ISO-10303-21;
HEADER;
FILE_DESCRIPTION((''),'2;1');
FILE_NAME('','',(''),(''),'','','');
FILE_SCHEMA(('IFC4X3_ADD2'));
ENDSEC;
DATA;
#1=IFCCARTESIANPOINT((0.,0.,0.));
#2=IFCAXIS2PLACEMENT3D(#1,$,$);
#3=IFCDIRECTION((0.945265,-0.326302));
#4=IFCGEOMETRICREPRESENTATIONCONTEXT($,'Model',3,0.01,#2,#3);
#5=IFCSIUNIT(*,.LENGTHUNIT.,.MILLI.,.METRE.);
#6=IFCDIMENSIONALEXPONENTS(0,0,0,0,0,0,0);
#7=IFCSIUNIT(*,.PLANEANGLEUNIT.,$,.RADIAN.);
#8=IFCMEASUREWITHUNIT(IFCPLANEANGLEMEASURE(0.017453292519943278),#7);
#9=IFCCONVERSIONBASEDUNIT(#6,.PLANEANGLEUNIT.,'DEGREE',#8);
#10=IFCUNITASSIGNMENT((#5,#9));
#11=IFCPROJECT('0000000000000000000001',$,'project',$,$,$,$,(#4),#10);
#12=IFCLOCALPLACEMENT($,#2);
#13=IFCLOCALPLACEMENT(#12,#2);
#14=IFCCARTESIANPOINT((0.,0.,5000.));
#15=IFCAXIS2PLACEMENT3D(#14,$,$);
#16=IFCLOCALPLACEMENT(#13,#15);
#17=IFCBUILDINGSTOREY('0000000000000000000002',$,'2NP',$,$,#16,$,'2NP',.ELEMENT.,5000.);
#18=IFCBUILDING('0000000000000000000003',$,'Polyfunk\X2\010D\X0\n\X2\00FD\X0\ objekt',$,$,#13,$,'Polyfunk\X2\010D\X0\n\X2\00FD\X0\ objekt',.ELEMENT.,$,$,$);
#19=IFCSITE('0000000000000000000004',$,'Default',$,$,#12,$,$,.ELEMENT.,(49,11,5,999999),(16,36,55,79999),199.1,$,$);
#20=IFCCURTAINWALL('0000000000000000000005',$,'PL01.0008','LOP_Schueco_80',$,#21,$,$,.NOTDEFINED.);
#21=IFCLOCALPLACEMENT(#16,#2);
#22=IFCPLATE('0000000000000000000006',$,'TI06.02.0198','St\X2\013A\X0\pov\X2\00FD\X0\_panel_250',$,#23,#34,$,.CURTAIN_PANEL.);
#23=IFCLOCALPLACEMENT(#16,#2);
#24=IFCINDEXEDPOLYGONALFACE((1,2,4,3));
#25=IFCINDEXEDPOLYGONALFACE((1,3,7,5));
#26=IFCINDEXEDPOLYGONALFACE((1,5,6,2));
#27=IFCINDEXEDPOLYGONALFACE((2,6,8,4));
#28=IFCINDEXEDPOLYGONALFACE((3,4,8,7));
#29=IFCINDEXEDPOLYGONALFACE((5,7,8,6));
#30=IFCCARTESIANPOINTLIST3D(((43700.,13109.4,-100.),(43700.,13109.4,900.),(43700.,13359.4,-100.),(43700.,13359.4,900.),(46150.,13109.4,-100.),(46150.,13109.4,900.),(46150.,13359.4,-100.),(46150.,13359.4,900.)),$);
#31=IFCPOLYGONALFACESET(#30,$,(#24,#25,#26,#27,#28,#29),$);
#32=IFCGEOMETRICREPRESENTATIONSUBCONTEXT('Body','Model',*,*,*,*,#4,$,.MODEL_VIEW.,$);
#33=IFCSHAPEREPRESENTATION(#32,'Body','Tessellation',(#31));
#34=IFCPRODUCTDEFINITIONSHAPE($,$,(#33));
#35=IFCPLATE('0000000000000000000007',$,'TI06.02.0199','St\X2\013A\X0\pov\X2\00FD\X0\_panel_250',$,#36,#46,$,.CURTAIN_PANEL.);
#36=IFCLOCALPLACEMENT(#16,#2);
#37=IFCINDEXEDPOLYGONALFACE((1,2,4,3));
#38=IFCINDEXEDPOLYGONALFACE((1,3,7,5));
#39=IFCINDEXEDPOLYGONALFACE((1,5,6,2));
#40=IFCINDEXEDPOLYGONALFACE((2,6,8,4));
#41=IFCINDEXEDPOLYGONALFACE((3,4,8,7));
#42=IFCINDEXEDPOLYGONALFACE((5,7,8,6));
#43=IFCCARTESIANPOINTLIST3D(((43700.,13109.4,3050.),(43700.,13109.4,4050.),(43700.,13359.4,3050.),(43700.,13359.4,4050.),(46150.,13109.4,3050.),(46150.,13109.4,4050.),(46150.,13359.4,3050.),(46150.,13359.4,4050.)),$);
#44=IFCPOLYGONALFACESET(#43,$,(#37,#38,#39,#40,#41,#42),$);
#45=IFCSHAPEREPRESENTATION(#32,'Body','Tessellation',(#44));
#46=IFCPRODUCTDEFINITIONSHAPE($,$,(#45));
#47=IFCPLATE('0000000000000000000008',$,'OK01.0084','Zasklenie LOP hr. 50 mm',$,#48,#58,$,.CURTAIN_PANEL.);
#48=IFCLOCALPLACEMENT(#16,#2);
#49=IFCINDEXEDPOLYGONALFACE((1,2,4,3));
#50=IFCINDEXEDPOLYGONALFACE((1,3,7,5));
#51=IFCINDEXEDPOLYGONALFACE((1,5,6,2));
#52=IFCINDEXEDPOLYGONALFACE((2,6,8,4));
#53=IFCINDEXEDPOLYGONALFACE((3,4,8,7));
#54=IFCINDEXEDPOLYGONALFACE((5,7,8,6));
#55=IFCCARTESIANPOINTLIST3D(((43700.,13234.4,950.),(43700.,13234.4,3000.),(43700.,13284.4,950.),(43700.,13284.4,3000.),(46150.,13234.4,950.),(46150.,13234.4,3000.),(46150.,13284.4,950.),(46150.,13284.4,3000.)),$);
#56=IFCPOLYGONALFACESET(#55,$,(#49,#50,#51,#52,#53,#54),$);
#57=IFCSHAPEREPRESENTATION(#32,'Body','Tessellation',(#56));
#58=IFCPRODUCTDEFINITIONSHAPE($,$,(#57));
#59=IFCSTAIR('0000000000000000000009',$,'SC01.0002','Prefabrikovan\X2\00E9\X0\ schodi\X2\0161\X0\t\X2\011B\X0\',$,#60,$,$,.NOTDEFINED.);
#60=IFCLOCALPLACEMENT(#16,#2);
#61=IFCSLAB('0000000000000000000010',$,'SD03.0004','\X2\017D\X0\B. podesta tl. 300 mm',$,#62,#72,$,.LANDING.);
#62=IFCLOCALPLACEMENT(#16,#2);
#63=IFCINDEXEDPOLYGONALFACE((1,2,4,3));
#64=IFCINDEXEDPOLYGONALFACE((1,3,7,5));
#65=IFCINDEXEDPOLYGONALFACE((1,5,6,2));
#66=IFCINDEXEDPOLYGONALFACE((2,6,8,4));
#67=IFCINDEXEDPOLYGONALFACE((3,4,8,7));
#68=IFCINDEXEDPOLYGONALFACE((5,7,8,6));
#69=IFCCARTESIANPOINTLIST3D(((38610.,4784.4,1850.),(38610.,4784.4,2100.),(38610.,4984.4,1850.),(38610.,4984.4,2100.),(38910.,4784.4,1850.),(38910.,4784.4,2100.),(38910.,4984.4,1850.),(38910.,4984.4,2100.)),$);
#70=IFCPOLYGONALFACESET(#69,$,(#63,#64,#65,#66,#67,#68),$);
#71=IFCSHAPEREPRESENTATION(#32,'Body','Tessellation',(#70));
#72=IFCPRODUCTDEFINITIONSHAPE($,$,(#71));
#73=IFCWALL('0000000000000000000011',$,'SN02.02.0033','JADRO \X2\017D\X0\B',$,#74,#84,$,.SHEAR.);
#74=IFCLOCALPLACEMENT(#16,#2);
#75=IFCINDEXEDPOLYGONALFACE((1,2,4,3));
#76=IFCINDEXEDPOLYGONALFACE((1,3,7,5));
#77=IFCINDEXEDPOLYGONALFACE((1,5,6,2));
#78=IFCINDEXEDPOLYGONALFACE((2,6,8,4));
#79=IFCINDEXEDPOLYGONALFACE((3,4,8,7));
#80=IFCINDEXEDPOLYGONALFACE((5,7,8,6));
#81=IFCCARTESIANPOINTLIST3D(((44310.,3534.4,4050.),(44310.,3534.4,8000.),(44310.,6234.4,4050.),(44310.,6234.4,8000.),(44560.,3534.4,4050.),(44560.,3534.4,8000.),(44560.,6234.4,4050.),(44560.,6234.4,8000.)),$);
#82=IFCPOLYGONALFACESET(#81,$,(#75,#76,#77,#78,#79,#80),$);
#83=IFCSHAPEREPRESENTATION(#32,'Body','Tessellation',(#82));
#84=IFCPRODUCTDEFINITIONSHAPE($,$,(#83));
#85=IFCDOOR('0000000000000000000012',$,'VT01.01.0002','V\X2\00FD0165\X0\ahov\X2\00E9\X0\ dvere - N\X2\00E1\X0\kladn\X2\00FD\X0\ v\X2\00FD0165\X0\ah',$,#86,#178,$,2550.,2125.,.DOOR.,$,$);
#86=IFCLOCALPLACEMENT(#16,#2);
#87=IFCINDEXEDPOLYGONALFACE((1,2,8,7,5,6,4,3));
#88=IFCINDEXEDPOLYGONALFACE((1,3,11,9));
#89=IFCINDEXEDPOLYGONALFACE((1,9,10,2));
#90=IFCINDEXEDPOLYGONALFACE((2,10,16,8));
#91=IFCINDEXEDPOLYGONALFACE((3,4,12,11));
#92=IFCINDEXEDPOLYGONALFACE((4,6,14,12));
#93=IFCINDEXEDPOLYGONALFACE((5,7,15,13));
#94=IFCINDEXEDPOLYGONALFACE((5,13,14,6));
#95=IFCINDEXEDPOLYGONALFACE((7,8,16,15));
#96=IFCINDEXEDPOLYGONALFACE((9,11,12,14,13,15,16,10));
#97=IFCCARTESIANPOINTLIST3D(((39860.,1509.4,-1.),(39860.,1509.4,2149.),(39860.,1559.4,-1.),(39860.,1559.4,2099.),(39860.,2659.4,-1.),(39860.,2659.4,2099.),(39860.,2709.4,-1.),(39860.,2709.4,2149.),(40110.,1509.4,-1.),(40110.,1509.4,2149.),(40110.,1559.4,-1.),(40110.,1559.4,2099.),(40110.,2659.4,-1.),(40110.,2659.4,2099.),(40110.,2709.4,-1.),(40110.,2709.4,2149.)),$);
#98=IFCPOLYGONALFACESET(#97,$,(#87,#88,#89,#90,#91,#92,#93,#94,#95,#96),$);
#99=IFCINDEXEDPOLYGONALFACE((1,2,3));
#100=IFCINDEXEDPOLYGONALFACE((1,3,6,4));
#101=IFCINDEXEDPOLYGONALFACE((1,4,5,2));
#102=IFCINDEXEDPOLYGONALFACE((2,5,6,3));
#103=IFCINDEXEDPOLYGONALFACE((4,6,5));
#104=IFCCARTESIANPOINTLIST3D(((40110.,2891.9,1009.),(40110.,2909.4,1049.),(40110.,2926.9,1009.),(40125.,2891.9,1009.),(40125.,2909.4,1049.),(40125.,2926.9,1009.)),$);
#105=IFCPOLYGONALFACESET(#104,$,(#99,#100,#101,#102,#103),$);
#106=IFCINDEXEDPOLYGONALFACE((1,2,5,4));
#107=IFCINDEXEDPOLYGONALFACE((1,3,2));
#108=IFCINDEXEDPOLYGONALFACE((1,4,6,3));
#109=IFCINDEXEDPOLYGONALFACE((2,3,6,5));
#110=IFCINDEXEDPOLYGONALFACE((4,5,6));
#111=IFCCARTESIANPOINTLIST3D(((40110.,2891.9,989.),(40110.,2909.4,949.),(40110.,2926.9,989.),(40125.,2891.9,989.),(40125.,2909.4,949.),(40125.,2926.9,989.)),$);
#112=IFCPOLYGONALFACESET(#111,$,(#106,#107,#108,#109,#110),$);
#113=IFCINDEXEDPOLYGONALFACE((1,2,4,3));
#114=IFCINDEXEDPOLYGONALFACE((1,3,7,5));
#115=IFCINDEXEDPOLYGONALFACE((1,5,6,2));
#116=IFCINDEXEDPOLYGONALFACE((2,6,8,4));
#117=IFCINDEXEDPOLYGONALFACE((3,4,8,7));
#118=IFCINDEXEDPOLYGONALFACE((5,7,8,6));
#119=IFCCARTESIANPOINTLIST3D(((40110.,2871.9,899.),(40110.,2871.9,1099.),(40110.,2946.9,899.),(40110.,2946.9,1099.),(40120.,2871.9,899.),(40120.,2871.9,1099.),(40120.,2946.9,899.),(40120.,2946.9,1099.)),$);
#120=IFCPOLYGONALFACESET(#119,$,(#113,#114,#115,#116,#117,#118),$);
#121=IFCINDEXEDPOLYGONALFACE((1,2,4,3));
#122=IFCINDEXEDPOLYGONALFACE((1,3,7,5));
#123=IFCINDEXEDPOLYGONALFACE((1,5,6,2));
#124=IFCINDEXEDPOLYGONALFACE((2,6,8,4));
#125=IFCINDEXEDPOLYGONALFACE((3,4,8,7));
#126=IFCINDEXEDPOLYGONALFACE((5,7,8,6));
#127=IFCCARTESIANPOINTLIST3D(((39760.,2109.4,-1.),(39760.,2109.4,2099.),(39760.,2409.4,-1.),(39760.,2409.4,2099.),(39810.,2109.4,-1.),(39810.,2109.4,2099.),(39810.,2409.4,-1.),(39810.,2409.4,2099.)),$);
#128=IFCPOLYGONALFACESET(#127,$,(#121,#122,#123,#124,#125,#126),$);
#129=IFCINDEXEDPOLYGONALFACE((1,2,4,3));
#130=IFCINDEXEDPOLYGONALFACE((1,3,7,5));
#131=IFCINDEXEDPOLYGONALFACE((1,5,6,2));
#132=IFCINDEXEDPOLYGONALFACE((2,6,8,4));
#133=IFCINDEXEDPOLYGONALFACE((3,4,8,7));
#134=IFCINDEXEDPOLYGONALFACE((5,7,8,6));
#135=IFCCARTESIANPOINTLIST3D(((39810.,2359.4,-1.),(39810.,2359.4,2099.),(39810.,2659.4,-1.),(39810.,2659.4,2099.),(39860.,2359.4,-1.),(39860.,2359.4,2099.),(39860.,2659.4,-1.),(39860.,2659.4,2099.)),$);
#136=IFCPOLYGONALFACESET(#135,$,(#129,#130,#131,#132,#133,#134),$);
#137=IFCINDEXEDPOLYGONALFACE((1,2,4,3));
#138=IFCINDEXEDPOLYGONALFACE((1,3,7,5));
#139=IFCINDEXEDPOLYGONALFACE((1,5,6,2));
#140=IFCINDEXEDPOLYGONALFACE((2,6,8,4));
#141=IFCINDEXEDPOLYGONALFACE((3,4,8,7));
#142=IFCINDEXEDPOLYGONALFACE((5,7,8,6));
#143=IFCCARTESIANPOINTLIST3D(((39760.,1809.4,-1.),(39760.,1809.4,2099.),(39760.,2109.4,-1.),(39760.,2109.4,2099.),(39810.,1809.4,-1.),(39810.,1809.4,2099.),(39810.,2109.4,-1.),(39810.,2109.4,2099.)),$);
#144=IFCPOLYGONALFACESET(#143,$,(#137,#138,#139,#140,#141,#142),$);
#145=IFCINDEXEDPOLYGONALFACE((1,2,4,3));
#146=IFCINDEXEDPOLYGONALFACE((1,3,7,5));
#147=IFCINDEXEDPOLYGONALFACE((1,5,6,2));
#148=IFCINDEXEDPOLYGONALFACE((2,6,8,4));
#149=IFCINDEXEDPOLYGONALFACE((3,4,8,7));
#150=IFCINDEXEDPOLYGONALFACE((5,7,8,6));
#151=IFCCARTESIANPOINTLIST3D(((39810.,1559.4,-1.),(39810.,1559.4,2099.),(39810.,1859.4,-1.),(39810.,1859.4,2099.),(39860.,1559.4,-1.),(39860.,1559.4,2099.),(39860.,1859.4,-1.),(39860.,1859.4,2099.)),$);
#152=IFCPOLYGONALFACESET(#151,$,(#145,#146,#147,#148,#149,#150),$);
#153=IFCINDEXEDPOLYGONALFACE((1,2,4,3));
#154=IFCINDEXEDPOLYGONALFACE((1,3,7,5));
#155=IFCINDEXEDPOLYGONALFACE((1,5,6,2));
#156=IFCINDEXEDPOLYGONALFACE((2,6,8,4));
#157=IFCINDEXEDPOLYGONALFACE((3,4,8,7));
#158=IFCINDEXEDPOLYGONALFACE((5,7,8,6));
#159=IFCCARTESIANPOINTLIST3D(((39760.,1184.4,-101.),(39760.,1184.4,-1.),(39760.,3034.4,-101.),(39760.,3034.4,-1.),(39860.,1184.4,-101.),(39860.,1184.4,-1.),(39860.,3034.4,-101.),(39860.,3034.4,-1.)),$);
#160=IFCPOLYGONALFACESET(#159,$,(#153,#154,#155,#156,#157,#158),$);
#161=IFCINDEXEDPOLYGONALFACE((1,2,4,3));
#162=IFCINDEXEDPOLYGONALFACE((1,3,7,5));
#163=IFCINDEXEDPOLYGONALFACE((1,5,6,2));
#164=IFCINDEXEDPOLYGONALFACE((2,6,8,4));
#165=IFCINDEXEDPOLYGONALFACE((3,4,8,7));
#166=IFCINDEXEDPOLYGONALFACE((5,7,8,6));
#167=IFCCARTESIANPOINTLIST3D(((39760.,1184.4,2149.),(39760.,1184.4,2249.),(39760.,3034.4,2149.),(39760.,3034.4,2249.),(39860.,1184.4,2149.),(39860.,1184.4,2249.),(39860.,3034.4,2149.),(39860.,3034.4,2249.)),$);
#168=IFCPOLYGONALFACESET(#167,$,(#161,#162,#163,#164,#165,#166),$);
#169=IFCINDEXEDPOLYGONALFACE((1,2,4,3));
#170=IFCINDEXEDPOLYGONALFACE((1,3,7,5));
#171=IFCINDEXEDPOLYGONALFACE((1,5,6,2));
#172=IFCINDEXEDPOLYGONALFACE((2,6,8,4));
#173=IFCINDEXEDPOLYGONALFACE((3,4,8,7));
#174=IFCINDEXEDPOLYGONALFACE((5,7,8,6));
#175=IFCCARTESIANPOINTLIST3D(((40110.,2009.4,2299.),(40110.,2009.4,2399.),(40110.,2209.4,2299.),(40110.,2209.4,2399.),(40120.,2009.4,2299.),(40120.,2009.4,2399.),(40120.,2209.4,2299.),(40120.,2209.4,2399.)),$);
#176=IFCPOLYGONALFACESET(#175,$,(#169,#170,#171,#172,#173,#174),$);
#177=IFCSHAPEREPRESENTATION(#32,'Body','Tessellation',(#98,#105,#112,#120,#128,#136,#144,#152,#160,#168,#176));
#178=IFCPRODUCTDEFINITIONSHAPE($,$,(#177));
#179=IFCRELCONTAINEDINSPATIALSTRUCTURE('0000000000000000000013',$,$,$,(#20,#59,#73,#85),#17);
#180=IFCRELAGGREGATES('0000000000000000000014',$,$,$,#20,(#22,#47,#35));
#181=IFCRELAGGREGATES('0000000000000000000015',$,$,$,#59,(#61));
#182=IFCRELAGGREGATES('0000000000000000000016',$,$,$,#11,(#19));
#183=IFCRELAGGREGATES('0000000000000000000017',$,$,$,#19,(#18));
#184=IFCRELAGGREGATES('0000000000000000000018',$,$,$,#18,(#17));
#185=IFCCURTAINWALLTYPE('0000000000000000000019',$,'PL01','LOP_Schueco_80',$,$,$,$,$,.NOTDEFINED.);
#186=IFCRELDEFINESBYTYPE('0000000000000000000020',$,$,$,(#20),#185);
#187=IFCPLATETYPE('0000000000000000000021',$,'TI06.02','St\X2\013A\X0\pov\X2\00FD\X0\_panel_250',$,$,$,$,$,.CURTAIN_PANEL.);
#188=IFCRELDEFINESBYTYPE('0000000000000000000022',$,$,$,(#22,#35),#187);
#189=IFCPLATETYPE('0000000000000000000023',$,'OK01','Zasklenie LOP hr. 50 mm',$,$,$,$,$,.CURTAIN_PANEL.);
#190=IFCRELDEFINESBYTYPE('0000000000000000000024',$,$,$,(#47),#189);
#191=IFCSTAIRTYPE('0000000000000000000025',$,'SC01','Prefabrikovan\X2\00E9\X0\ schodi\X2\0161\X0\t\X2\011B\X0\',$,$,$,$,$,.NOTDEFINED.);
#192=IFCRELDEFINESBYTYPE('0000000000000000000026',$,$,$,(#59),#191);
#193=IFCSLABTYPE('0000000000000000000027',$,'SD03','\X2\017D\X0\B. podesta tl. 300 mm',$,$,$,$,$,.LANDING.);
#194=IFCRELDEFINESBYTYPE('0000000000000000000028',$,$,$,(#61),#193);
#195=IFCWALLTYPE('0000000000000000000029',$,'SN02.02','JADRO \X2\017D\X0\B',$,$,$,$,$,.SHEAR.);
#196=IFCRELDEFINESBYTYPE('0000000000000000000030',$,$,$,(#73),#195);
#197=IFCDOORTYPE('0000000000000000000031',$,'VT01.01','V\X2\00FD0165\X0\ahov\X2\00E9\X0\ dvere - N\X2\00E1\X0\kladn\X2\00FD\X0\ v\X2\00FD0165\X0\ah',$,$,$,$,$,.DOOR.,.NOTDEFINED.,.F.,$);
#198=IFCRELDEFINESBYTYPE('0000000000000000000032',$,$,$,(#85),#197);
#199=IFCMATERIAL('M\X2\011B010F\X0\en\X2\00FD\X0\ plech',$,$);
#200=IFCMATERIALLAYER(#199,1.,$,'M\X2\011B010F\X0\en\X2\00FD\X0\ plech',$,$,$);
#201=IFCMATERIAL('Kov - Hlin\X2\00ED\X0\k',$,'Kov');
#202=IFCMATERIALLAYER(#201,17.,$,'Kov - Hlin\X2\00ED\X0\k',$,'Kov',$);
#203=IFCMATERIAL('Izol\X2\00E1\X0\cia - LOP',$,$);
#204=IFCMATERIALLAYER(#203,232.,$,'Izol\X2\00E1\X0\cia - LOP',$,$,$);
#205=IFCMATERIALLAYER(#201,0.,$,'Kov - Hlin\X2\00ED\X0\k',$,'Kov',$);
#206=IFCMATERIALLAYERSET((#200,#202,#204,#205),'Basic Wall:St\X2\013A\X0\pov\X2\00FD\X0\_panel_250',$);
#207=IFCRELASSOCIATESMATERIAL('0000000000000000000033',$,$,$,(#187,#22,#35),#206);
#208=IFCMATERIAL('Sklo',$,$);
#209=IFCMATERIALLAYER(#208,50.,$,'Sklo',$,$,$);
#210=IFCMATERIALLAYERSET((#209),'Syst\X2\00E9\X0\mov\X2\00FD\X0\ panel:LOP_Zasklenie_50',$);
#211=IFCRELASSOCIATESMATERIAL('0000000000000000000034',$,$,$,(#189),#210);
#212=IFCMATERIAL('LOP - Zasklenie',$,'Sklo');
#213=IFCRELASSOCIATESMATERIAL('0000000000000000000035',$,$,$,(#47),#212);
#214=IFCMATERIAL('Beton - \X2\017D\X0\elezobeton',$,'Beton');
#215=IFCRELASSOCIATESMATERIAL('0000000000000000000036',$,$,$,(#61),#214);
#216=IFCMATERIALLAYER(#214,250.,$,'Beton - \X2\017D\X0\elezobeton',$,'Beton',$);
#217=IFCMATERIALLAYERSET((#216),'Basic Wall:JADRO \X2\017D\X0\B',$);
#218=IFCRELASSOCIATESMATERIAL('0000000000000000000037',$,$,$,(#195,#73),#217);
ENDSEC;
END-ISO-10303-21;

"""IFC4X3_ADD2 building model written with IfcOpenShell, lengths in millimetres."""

from ifc_helpers import new_model, entity, si_unit, converted_unit, direction, frame, frame_2d, origin, origin_2d_with_axis, place, context, subcontext, project, spatial, polyline, rectangle, outline, extrude, clip, bounded_halfspace, source, transform, mapped, material, layer, layer_set, layer_usage, type_object, type_shapes, element, aggregate, save


model = new_model("IFC4X3_ADD2")

# Units and contexts
model_context = context("Model", 3, precision=0.01, world=origin(), true_north=direction((0.945265, -0.326302)))
body_context = subcontext(model_context, "Body", "Model", "MODEL_VIEW")
ifc_project = project(units=[si_unit("LENGTHUNIT", "METRE", prefix="MILLI"), converted_unit("PLANEANGLEUNIT", "DEGREE", entity("IfcPlaneAngleMeasure", 0.017453292519943278), si_unit("PLANEANGLEUNIT", "RADIAN"), dimensions=[0, 0, 0, 0, 0, 0, 0])], contexts=[model_context])

# Site, building, storey
site_placement = place(None, origin())
site = spatial("IfcSite", under=ifc_project, at=site_placement, Name="Default", CompositionType="ELEMENT", RefLatitude=(49, 11, 5, 999999), RefLongitude=(16, 36, 55, 79999), RefElevation=199.1)
building_placement = place(site_placement, origin())
building = spatial("IfcBuilding", under=site, at=building_placement, Name="Polyfunkčný objekt", LongName="Polyfunkčný objekt", CompositionType="ELEMENT")
storey_placement = place(building_placement, frame((0.0, 0.0, 5000.0)))
storey = spatial("IfcBuildingStorey", under=building, at=storey_placement, Name="2NP", LongName="2NP", CompositionType="ELEMENT", Elevation=5000.0)

# Curtain wall, plates
curtain_wall_type = type_object("IfcCurtainWallType", Name="PL01", Description="LOP_Schueco_80", PredefinedType="NOTDEFINED")
curtain_wall_placement = place(storey_placement, frame((0.0, 0.0, -5000.0)))
curtain_wall = element("IfcCurtainWall", 1, at=curtain_wall_placement, inside=storey, type_object=curtain_wall_type, Name="PL01.0008", Description="LOP_Schueco_80", PredefinedType="NOTDEFINED")
ifc_material_1 = material(Name="Měďený plech")
ifc_layer_1 = layer(ifc_material_1, 1.0, Name="Měďený plech")
ifc_material_2 = material(Name="Kov - Hliník", Category="Kov")
ifc_layer_2 = layer(ifc_material_2, 17.0, Name="Kov - Hliník", Category="Kov")
ifc_material_3 = material(Name="Izolácia - LOP")
ifc_layer_3 = layer(ifc_material_3, 232.0, Name="Izolácia - LOP")
ifc_layer_4 = layer(ifc_material_2, 0.0, Name="Kov - Hliník", Category="Kov")
ifc_layer_set_1 = layer_set([ifc_layer_1, ifc_layer_2, ifc_layer_3, ifc_layer_4], Name="Basic Wall:Stĺpový_panel_250")
ifc_layer_usage_1 = layer_usage(ifc_layer_set_1, "AXIS2", "NEGATIVE", 125.0)
plate_type_1 = type_object("IfcPlateType", Name="TI06.02", Description="Stĺpový_panel_250", PredefinedType="CURTAIN_PANEL", material=ifc_layer_set_1)
plate_1_placement = place(storey_placement, frame((43700.0, 13234.4, -100.0)))
plate_1 = element("IfcPlate", 2, at=plate_1_placement, type_object=plate_type_1, material=ifc_layer_usage_1, Name="TI06.02.0198", Description="Stĺpový_panel_250", PredefinedType="CURTAIN_PANEL", context=body_context, shape_type="SweptSolid", body=[
    extrude(rectangle(XDim=250.0, YDim=2450.0, at=frame_2d((0.0, 0.0), x_axis=(1.0, 0.0))), frame((1225.0, 0.0, 0.0), z_axis=(0.0, 0.0, 1.0), x_axis=(0.0, 1.0, 0.0)), (0.0, 0.0, 1.0), 1000.0),
])
ifc_layer_usage_2 = layer_usage(ifc_layer_set_1, "AXIS2", "NEGATIVE", 125.0)
plate_2_placement = place(storey_placement, frame((43700.0, 13234.4, 3050.0)))
plate_2 = element("IfcPlate", 3, at=plate_2_placement, type_object=plate_type_1, material=ifc_layer_usage_2, Name="TI06.02.0199", Description="Stĺpový_panel_250", PredefinedType="CURTAIN_PANEL", context=body_context, shape_type="SweptSolid", body=[
    extrude(rectangle(XDim=250.0, YDim=2450.0, at=frame_2d((0.0, 0.0), x_axis=(1.0, 0.0))), frame((1225.0, 0.0, 0.0), z_axis=(0.0, 0.0, 1.0), x_axis=(0.0, 1.0, 0.0)), (0.0, 0.0, 1.0), 1000.0),
])
ifc_material_4 = material(Name="LOP - Zasklenie", Category="Sklo")
ifc_material_5 = material(Name="Sklo")
ifc_layer_5 = layer(ifc_material_5, 50.0, Name="Sklo")
ifc_layer_set_2 = layer_set([ifc_layer_5], Name="Systémový panel:LOP_Zasklenie_50")
plate_type_2 = type_object("IfcPlateType", Name="OK01", Description="Zasklenie LOP hr. 50 mm", PredefinedType="CURTAIN_PANEL", material=ifc_layer_set_2)
shared_shape_1 = source(origin(), body_context, "Body", "SweptSolid", [
    extrude(rectangle(XDim=50.0, YDim=2450.0, at=origin_2d_with_axis()), frame((0.0, 25.0, 0.0), z_axis=(0.0, 0.0, 1.0), x_axis=(0.0, 1.0, 0.0)), (0.0, 0.0, 1.0), 2050.0),
])
type_shapes(plate_type_2, [shared_shape_1])
plate_3_placement = place(curtain_wall_placement, frame((44925.0, 13234.4, 5950.0)))
plate_3 = element("IfcPlate", 4, at=plate_3_placement, type_object=plate_type_2, material=ifc_material_4, Name="OK01.0084", Description="Zasklenie LOP hr. 50 mm", PredefinedType="CURTAIN_PANEL", context=body_context, shape_type="MappedRepresentation", body=[
    mapped(shared_shape_1, transform((0.0, 0.0, 0.0), scale=1.0)),
])
aggregate(curtain_wall, [plate_1, plate_3, plate_2])

# Stair, slab
stair_type = type_object("IfcStairType", Name="SC01", Description="Prefabrikované schodiště", PredefinedType="NOTDEFINED")
stair_placement = place(storey_placement, origin())
stair = element("IfcStair", 5, at=stair_placement, inside=storey, type_object=stair_type, Name="SC01.0002", Description="Prefabrikované schodiště", PredefinedType="NOTDEFINED")
ifc_material_6 = material(Name="Beton - Železobeton", Category="Beton")
slab_type = type_object("IfcSlabType", Name="SD03", Description="ŽB. podesta tl. 300 mm", PredefinedType="LANDING")
slab_placement = place(stair_placement, frame((38610.0, 4784.4, 0.0)))
slab = element("IfcSlab", 6, at=slab_placement, type_object=slab_type, material=ifc_material_6, Name="SD03.0004", Description="ŽB. podesta tl. 300 mm", PredefinedType="LANDING", context=body_context, shape_type="SweptSolid", body=[
    extrude(rectangle(XDim=200.0, YDim=300.0, at=frame_2d((0.0, 0.0), x_axis=(1.0, 0.0))), frame((150.0, 100.0, 1850.0), z_axis=(0.0, 0.0, 1.0), x_axis=(0.0, 1.0, 0.0)), (0.0, 0.0, 1.0), 250.0),
])
aggregate(stair, [slab])

# Wall
ifc_layer_6 = layer(ifc_material_6, 250.0, Name="Beton - Železobeton", Category="Beton")
ifc_layer_set_3 = layer_set([ifc_layer_6], Name="Basic Wall:JADRO ŽB")
wall_type = type_object("IfcWallType", Name="SN02.02", Description="JADRO ŽB", PredefinedType="SHEAR", material=ifc_layer_set_3)
wall_placement = place(storey_placement, frame((44435.0, 6234.4, 4050.0), z_axis=(0.0, 0.0, 1.0), x_axis=(0.0, -1.0, 0.0)))
element("IfcWall", 7, at=wall_placement, inside=storey, type_object=wall_type, material=ifc_layer_set_3, Name="SN02.02.0033", Description="JADRO ŽB", PredefinedType="SHEAR", context=body_context, shape_type="Clipping", body=[
    clip(clip(extrude(rectangle(XDim=2700.0, YDim=250.0, at=frame_2d((1350.0, 0.0), x_axis=(-1.0, 0.0))), origin(), (0.0, 0.0, 1.0), 3950.0), bounded_halfspace(frame((2700.0, -125.0, 0.0), z_axis=(0.0, 0.0, 1.0), x_axis=(0.0, -1.0, 0.0)), True, frame((2700.0, -125.0, 0.0)), polyline([(0.0, 0.0), (0.0, 250.0), (-2700.0, 250.0), (-2700.0, 0.0), (0.0, 0.0)]))), bounded_halfspace(frame((0.0, -125.0, 3950.0), z_axis=(0.0, 0.0, -1.0), x_axis=(0.0, 1.0, 0.0)), True, frame((0.0, -125.0, 3950.0)), polyline([(0.0, 0.0), (2700.0, 0.0), (2700.0, 250.0), (0.0, 250.0), (0.0, 0.0)]))),
])

# Door
door_type = type_object("IfcDoorType", Name="VT01.01", Description="Výťahové dvere - Nákladný výťah", OperationType="NOTDEFINED", ParameterTakesPrecedence=False, PredefinedType="DOOR")
shared_shape_2 = source(origin(), body_context, "Body", "SweptSolid", [
    extrude(outline(polyline([(-1087.5, -600.0), (1062.5, -600.0), (1062.5, -550.0), (-1037.5, -550.0), (-1037.5, 550.0), (1062.5, 550.0), (1062.5, 600.0), (-1087.5, 600.0), (-1087.5, -600.0)])), frame((600.0, 0.0, 1062.5), z_axis=(0.0, 1.0, 0.0), x_axis=(0.0, 0.0, -1.0)), (0.0, 0.0, 1.0), 250.0),
    extrude(outline(polyline([(-24.4, -10.7), (19.2, -10.7), (5.2, 21.4), (-24.4, -10.7)])), frame((1400.0, -15.0, 1023.3), z_axis=(0.0, 1.0, 0.0), x_axis=(0.400819, 0.0, -0.916157)), (0.0, 0.0, 1.0), 15.0),
    extrude(outline(polyline([(-24.4, -10.7), (19.2, -10.7), (5.2, 21.4), (-24.4, -10.7)])), frame((1400.0, -15.0, 976.7), z_axis=(0.0, 1.0, 0.0), x_axis=(-0.400819, 0.0, 0.916157)), (0.0, 0.0, 1.0), 15.0),
    extrude(rectangle(XDim=10.0, YDim=75.0, at=frame_2d((0.0, 0.0), x_axis=(1.0, 0.0))), frame((1400.0, -5.0, 900.0), z_axis=(0.0, 0.0, 1.0), x_axis=(0.0, 1.0, 0.0)), (0.0, 0.0, 1.0), 200.0),
    extrude(rectangle(XDim=50.0, YDim=300.0, at=origin_2d_with_axis()), frame((750.0, 325.0, 0.0), z_axis=(0.0, 0.0, 1.0), x_axis=(0.0, -1.0, 0.0)), (0.0, 0.0, 1.0), 2100.0),
    extrude(rectangle(XDim=50.0, YDim=300.0, at=frame_2d((0.0, 0.0), x_axis=(1.0, 0.0))), frame((1000.0, 275.0, 0.0), z_axis=(0.0, 0.0, 1.0), x_axis=(0.0, -1.0, 0.0)), (0.0, 0.0, 1.0), 2100.0),
    extrude(rectangle(XDim=300.0, YDim=50.0, at=frame_2d((0.0, 0.0), x_axis=(1.0, 0.0))), frame((450.0, 325.0, 0.0), z_axis=(0.0, 0.0, 1.0), x_axis=(-1.0, 0.0, 0.0)), (0.0, 0.0, 1.0), 2100.0),
    extrude(rectangle(XDim=300.0, YDim=50.0, at=frame_2d((0.0, 0.0), x_axis=(1.0, 0.0))), frame((200.0, 275.0, 0.0), z_axis=(0.0, 0.0, 1.0), x_axis=(-1.0, 0.0, 0.0)), (0.0, 0.0, 1.0), 2100.0),
    extrude(rectangle(XDim=1850.0, YDim=100.0, at=frame_2d((0.0, 0.0), x_axis=(1.0, 0.0))), frame((600.0, 300.0, -100.0), z_axis=(0.0, 0.0, 1.0), x_axis=(-1.0, 0.0, 0.0)), (0.0, 0.0, 1.0), 100.0),
    extrude(rectangle(XDim=1850.0, YDim=100.0, at=frame_2d((0.0, 0.0), x_axis=(1.0, 0.0))), frame((600.0, 300.0, 2150.0), z_axis=(0.0, 0.0, 1.0), x_axis=(-1.0, 0.0, 0.0)), (0.0, 0.0, 1.0), 100.0),
    extrude(rectangle(XDim=10.0, YDim=200.0, at=frame_2d((0.0, 0.0), x_axis=(1.0, 0.0))), frame((600.0, -5.0, 2300.0), z_axis=(0.0, 0.0, 1.0), x_axis=(0.0, 1.0, 0.0)), (0.0, 0.0, 1.0), 100.0),
])
type_shapes(door_type, [shared_shape_2])
door_placement = place(storey_placement, frame((40110.0, 1509.4, -1.0), z_axis=(0.0, 0.0, 1.0), x_axis=(0.0, 1.0, 0.0)))
element("IfcDoor", 8, at=door_placement, inside=storey, type_object=door_type, Name="VT01.01.0002", Description="Výťahové dvere - Nákladný výťah", OverallHeight=2550.0, OverallWidth=2125.0, PredefinedType="DOOR", context=body_context, shape_type="MappedRepresentation", body=[
    mapped(shared_shape_2, transform((0.0, 0.0, 0.0), scale=1.0)),
])

save(model, "model.ifc")
